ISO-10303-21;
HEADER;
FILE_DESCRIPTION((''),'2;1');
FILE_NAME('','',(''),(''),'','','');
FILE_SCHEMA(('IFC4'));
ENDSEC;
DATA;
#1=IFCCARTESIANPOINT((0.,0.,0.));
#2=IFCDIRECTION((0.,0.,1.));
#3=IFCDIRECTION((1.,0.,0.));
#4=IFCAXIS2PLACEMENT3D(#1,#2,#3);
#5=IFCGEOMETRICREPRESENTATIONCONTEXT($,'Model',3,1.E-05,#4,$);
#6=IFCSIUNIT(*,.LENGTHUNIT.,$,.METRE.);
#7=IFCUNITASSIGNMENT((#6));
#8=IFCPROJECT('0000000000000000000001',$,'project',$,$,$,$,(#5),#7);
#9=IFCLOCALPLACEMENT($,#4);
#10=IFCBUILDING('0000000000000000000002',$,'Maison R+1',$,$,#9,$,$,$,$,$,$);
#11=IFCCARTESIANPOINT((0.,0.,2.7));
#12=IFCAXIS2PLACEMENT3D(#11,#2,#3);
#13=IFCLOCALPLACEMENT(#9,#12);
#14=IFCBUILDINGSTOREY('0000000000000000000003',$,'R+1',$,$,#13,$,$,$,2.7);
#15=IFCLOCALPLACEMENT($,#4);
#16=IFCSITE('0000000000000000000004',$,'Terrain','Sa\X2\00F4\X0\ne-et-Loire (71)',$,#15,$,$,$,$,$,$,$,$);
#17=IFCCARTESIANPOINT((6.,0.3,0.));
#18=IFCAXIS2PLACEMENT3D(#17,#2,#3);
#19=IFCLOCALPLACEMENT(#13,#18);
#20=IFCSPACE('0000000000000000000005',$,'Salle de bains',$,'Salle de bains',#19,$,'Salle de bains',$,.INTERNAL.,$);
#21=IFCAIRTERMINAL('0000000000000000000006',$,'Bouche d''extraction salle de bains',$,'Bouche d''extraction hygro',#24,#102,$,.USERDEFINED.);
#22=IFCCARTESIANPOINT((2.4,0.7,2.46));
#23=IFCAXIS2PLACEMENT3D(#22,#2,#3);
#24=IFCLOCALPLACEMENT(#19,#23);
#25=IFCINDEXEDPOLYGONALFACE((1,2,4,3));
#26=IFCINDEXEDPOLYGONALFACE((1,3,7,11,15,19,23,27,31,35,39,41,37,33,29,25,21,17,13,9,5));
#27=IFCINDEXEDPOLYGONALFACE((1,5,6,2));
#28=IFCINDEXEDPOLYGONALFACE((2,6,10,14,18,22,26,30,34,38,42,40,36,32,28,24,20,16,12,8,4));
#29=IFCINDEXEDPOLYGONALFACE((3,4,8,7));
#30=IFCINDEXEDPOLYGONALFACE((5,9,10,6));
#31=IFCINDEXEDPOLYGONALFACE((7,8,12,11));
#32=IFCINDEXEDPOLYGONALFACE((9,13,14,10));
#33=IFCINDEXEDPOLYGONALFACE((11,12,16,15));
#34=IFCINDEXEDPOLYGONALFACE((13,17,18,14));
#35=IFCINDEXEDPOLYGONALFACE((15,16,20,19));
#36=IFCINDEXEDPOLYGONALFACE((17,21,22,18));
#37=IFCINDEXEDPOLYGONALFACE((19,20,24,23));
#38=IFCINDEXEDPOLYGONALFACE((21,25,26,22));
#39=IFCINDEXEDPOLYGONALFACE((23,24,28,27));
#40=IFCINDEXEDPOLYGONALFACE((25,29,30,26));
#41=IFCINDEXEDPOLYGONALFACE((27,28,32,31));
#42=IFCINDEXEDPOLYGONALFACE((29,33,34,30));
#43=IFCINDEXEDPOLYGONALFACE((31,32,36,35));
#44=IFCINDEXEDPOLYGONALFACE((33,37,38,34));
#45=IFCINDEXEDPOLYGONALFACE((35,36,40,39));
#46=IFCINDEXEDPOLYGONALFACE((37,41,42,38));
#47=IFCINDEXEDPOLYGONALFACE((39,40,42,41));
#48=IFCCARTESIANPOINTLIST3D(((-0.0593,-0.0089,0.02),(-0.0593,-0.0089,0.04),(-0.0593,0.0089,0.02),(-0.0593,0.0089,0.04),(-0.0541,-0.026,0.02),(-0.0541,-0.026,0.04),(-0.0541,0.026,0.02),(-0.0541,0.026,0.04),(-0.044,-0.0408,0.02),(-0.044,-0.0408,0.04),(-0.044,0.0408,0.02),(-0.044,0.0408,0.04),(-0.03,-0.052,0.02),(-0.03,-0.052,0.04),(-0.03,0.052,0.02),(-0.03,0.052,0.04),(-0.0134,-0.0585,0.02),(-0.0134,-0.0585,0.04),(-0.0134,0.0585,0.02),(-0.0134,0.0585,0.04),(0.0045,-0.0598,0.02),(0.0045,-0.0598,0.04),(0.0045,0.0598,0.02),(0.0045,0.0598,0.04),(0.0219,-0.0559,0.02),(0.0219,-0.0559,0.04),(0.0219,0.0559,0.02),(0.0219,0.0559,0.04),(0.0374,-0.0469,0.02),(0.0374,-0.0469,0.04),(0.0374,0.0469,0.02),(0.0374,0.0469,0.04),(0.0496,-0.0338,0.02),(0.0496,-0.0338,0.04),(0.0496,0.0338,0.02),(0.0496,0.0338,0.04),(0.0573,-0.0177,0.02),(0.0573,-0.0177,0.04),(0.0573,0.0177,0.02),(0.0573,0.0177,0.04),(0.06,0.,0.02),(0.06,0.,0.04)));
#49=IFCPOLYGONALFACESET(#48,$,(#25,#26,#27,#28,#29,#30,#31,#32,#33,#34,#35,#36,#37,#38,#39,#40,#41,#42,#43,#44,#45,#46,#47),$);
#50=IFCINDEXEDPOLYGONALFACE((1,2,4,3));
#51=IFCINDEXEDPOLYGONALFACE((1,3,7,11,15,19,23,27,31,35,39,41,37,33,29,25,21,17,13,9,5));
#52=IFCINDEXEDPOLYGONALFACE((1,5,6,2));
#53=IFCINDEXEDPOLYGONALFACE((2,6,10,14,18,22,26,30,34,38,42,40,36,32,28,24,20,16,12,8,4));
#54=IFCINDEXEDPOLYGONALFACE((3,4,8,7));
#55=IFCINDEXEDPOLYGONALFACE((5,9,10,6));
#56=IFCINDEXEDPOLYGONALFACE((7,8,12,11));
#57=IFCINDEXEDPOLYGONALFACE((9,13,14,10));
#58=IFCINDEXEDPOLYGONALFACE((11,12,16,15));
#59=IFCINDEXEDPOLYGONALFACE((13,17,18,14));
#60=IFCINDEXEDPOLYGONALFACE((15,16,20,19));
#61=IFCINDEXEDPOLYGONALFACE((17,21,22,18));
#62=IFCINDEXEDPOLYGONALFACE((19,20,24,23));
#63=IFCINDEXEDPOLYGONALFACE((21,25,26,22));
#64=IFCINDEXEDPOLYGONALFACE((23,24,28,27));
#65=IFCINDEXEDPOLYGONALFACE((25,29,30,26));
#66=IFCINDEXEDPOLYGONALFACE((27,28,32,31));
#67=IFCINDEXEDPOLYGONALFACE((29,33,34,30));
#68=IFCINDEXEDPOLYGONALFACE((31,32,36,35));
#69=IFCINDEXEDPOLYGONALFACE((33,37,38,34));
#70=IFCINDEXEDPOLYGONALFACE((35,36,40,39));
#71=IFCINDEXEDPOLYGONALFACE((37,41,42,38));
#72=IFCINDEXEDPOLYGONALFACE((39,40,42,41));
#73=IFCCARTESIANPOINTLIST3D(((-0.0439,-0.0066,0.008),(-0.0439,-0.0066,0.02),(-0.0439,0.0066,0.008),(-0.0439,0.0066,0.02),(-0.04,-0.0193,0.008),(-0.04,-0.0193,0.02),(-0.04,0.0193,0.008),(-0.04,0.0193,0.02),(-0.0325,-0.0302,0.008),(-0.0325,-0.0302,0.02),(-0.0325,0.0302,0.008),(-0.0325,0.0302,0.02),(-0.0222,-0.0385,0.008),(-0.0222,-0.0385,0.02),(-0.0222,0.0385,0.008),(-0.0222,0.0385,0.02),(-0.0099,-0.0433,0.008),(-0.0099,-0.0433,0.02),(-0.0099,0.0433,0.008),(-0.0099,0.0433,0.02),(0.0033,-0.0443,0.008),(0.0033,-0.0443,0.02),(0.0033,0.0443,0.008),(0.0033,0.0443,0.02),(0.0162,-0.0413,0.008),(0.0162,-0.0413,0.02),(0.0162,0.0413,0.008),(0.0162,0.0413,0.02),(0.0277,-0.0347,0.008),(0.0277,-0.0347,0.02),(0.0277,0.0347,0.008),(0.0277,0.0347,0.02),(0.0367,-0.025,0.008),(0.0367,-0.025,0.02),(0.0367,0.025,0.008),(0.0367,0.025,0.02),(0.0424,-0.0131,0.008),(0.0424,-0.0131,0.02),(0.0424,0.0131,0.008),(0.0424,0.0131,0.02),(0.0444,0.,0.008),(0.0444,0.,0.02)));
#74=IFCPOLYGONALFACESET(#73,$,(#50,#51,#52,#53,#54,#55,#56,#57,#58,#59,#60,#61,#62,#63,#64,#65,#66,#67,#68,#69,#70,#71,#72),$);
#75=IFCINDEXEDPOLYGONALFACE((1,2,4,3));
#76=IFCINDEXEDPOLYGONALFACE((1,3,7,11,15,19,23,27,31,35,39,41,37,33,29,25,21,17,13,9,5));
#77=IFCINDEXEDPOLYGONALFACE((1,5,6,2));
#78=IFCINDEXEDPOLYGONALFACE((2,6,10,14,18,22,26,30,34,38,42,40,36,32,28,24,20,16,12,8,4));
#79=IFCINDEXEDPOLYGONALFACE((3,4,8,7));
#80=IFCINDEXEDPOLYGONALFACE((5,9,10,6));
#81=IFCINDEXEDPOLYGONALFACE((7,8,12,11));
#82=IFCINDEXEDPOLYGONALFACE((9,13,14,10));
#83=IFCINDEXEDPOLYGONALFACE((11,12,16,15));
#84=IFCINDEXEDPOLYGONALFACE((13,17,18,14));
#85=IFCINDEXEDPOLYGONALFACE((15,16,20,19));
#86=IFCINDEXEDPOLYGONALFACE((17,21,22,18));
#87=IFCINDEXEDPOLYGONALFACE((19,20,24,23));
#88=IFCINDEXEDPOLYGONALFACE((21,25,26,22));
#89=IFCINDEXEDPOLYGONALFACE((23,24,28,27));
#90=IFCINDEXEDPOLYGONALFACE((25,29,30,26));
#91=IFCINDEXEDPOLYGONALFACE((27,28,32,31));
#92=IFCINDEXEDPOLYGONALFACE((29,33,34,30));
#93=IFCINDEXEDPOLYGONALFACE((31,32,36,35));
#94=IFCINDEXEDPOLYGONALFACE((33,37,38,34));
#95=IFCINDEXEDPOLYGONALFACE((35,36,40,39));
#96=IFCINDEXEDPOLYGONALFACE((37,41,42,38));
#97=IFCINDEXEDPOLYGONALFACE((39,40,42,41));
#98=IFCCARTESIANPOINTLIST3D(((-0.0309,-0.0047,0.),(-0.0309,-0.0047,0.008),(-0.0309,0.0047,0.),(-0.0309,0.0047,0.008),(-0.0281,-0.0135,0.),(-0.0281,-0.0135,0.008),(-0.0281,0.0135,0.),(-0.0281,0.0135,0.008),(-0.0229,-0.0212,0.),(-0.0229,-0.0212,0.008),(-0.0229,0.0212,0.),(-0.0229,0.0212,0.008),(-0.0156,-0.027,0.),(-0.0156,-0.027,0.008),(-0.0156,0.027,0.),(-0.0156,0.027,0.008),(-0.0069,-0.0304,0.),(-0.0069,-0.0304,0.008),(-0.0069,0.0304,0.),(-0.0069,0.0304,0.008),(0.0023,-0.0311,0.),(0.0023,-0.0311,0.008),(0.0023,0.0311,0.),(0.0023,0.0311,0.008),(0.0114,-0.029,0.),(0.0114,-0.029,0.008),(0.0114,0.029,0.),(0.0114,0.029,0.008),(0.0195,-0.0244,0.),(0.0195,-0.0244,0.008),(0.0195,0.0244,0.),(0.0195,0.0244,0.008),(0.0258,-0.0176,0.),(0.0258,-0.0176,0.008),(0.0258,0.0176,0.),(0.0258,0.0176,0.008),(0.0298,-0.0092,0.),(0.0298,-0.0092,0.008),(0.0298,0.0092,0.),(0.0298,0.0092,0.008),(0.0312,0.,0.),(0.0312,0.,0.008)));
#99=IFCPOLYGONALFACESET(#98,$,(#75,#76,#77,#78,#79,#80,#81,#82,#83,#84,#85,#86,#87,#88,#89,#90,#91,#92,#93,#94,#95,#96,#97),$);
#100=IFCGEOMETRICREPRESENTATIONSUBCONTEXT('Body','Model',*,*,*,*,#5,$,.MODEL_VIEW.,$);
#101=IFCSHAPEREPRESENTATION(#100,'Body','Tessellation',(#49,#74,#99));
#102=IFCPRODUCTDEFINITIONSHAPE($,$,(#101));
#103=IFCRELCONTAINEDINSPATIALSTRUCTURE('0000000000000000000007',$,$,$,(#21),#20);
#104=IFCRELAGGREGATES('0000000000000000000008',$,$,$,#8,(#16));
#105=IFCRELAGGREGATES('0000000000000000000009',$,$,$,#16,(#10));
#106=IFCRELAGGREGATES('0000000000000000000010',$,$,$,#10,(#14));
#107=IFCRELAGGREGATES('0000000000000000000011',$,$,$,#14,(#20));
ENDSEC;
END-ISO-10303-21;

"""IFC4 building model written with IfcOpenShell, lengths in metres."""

from ifc_helpers import new_model, si_unit, frame, origin_with_axes, place, context, subcontext, project, spatial, circle, extrude, element, save


model = new_model("IFC4")

# Units and contexts
model_context = context("Model", 3, precision=1e-05, world=origin_with_axes())
body_context = subcontext(model_context, "Body", "Model", "MODEL_VIEW")
ifc_project = project(units=[si_unit("LENGTHUNIT", "METRE")], contexts=[model_context])

# Site, building, storey
site_placement = place(None, origin_with_axes())
site = spatial("IfcSite", under=ifc_project, at=site_placement, Name="Terrain", Description="Saône-et-Loire (71)")
building_placement = place(None, origin_with_axes())
building = spatial("IfcBuilding", under=site, at=building_placement, Name="Maison R+1")
storey_placement = place(building_placement, frame((0.0, 0.0, 2.7), z_axis=(0.0, 0.0, 1.0), x_axis=(1.0, 0.0, 0.0)))
storey = spatial("IfcBuildingStorey", under=building, at=storey_placement, Name="R+1", Elevation=2.7)

# Shared definitions
space_placement = place(storey_placement, frame((6.0, 0.3, 0.0), z_axis=(0.0, 0.0, 1.0), x_axis=(1.0, 0.0, 0.0)))
space = spatial("IfcSpace", under=storey, at=space_placement, Name="Salle de bains", ObjectType="Salle de bains", LongName="Salle de bains", PredefinedType="INTERNAL")

# Air terminal
air_terminal_placement = place(space_placement, frame((2.4, 0.7, 2.46), z_axis=(0.0, 0.0, 1.0), x_axis=(1.0, 0.0, 0.0)))
element("IfcAirTerminal", 1, at=air_terminal_placement, inside=space, Name="Bouche d'extraction salle de bains", ObjectType="Bouche d'extraction hygro", PredefinedType="USERDEFINED", context=body_context, shape_type="SweptSolid", body=[
    extrude(circle(Radius=0.06), frame((0.0, 0.0, 0.02), z_axis=(0.0, 0.0, 1.0), x_axis=(1.0, 0.0, 0.0)), (0.0, 0.0, 1.0), 0.02),
    extrude(circle(Radius=0.0444), frame((0.0, 0.0, 0.008), z_axis=(0.0, 0.0, 1.0), x_axis=(1.0, 0.0, 0.0)), (0.0, 0.0, 1.0), 0.012),
    extrude(circle(Radius=0.0312), origin_with_axes(), (0.0, 0.0, 1.0), 0.008),
])

save(model, "model.ifc")
